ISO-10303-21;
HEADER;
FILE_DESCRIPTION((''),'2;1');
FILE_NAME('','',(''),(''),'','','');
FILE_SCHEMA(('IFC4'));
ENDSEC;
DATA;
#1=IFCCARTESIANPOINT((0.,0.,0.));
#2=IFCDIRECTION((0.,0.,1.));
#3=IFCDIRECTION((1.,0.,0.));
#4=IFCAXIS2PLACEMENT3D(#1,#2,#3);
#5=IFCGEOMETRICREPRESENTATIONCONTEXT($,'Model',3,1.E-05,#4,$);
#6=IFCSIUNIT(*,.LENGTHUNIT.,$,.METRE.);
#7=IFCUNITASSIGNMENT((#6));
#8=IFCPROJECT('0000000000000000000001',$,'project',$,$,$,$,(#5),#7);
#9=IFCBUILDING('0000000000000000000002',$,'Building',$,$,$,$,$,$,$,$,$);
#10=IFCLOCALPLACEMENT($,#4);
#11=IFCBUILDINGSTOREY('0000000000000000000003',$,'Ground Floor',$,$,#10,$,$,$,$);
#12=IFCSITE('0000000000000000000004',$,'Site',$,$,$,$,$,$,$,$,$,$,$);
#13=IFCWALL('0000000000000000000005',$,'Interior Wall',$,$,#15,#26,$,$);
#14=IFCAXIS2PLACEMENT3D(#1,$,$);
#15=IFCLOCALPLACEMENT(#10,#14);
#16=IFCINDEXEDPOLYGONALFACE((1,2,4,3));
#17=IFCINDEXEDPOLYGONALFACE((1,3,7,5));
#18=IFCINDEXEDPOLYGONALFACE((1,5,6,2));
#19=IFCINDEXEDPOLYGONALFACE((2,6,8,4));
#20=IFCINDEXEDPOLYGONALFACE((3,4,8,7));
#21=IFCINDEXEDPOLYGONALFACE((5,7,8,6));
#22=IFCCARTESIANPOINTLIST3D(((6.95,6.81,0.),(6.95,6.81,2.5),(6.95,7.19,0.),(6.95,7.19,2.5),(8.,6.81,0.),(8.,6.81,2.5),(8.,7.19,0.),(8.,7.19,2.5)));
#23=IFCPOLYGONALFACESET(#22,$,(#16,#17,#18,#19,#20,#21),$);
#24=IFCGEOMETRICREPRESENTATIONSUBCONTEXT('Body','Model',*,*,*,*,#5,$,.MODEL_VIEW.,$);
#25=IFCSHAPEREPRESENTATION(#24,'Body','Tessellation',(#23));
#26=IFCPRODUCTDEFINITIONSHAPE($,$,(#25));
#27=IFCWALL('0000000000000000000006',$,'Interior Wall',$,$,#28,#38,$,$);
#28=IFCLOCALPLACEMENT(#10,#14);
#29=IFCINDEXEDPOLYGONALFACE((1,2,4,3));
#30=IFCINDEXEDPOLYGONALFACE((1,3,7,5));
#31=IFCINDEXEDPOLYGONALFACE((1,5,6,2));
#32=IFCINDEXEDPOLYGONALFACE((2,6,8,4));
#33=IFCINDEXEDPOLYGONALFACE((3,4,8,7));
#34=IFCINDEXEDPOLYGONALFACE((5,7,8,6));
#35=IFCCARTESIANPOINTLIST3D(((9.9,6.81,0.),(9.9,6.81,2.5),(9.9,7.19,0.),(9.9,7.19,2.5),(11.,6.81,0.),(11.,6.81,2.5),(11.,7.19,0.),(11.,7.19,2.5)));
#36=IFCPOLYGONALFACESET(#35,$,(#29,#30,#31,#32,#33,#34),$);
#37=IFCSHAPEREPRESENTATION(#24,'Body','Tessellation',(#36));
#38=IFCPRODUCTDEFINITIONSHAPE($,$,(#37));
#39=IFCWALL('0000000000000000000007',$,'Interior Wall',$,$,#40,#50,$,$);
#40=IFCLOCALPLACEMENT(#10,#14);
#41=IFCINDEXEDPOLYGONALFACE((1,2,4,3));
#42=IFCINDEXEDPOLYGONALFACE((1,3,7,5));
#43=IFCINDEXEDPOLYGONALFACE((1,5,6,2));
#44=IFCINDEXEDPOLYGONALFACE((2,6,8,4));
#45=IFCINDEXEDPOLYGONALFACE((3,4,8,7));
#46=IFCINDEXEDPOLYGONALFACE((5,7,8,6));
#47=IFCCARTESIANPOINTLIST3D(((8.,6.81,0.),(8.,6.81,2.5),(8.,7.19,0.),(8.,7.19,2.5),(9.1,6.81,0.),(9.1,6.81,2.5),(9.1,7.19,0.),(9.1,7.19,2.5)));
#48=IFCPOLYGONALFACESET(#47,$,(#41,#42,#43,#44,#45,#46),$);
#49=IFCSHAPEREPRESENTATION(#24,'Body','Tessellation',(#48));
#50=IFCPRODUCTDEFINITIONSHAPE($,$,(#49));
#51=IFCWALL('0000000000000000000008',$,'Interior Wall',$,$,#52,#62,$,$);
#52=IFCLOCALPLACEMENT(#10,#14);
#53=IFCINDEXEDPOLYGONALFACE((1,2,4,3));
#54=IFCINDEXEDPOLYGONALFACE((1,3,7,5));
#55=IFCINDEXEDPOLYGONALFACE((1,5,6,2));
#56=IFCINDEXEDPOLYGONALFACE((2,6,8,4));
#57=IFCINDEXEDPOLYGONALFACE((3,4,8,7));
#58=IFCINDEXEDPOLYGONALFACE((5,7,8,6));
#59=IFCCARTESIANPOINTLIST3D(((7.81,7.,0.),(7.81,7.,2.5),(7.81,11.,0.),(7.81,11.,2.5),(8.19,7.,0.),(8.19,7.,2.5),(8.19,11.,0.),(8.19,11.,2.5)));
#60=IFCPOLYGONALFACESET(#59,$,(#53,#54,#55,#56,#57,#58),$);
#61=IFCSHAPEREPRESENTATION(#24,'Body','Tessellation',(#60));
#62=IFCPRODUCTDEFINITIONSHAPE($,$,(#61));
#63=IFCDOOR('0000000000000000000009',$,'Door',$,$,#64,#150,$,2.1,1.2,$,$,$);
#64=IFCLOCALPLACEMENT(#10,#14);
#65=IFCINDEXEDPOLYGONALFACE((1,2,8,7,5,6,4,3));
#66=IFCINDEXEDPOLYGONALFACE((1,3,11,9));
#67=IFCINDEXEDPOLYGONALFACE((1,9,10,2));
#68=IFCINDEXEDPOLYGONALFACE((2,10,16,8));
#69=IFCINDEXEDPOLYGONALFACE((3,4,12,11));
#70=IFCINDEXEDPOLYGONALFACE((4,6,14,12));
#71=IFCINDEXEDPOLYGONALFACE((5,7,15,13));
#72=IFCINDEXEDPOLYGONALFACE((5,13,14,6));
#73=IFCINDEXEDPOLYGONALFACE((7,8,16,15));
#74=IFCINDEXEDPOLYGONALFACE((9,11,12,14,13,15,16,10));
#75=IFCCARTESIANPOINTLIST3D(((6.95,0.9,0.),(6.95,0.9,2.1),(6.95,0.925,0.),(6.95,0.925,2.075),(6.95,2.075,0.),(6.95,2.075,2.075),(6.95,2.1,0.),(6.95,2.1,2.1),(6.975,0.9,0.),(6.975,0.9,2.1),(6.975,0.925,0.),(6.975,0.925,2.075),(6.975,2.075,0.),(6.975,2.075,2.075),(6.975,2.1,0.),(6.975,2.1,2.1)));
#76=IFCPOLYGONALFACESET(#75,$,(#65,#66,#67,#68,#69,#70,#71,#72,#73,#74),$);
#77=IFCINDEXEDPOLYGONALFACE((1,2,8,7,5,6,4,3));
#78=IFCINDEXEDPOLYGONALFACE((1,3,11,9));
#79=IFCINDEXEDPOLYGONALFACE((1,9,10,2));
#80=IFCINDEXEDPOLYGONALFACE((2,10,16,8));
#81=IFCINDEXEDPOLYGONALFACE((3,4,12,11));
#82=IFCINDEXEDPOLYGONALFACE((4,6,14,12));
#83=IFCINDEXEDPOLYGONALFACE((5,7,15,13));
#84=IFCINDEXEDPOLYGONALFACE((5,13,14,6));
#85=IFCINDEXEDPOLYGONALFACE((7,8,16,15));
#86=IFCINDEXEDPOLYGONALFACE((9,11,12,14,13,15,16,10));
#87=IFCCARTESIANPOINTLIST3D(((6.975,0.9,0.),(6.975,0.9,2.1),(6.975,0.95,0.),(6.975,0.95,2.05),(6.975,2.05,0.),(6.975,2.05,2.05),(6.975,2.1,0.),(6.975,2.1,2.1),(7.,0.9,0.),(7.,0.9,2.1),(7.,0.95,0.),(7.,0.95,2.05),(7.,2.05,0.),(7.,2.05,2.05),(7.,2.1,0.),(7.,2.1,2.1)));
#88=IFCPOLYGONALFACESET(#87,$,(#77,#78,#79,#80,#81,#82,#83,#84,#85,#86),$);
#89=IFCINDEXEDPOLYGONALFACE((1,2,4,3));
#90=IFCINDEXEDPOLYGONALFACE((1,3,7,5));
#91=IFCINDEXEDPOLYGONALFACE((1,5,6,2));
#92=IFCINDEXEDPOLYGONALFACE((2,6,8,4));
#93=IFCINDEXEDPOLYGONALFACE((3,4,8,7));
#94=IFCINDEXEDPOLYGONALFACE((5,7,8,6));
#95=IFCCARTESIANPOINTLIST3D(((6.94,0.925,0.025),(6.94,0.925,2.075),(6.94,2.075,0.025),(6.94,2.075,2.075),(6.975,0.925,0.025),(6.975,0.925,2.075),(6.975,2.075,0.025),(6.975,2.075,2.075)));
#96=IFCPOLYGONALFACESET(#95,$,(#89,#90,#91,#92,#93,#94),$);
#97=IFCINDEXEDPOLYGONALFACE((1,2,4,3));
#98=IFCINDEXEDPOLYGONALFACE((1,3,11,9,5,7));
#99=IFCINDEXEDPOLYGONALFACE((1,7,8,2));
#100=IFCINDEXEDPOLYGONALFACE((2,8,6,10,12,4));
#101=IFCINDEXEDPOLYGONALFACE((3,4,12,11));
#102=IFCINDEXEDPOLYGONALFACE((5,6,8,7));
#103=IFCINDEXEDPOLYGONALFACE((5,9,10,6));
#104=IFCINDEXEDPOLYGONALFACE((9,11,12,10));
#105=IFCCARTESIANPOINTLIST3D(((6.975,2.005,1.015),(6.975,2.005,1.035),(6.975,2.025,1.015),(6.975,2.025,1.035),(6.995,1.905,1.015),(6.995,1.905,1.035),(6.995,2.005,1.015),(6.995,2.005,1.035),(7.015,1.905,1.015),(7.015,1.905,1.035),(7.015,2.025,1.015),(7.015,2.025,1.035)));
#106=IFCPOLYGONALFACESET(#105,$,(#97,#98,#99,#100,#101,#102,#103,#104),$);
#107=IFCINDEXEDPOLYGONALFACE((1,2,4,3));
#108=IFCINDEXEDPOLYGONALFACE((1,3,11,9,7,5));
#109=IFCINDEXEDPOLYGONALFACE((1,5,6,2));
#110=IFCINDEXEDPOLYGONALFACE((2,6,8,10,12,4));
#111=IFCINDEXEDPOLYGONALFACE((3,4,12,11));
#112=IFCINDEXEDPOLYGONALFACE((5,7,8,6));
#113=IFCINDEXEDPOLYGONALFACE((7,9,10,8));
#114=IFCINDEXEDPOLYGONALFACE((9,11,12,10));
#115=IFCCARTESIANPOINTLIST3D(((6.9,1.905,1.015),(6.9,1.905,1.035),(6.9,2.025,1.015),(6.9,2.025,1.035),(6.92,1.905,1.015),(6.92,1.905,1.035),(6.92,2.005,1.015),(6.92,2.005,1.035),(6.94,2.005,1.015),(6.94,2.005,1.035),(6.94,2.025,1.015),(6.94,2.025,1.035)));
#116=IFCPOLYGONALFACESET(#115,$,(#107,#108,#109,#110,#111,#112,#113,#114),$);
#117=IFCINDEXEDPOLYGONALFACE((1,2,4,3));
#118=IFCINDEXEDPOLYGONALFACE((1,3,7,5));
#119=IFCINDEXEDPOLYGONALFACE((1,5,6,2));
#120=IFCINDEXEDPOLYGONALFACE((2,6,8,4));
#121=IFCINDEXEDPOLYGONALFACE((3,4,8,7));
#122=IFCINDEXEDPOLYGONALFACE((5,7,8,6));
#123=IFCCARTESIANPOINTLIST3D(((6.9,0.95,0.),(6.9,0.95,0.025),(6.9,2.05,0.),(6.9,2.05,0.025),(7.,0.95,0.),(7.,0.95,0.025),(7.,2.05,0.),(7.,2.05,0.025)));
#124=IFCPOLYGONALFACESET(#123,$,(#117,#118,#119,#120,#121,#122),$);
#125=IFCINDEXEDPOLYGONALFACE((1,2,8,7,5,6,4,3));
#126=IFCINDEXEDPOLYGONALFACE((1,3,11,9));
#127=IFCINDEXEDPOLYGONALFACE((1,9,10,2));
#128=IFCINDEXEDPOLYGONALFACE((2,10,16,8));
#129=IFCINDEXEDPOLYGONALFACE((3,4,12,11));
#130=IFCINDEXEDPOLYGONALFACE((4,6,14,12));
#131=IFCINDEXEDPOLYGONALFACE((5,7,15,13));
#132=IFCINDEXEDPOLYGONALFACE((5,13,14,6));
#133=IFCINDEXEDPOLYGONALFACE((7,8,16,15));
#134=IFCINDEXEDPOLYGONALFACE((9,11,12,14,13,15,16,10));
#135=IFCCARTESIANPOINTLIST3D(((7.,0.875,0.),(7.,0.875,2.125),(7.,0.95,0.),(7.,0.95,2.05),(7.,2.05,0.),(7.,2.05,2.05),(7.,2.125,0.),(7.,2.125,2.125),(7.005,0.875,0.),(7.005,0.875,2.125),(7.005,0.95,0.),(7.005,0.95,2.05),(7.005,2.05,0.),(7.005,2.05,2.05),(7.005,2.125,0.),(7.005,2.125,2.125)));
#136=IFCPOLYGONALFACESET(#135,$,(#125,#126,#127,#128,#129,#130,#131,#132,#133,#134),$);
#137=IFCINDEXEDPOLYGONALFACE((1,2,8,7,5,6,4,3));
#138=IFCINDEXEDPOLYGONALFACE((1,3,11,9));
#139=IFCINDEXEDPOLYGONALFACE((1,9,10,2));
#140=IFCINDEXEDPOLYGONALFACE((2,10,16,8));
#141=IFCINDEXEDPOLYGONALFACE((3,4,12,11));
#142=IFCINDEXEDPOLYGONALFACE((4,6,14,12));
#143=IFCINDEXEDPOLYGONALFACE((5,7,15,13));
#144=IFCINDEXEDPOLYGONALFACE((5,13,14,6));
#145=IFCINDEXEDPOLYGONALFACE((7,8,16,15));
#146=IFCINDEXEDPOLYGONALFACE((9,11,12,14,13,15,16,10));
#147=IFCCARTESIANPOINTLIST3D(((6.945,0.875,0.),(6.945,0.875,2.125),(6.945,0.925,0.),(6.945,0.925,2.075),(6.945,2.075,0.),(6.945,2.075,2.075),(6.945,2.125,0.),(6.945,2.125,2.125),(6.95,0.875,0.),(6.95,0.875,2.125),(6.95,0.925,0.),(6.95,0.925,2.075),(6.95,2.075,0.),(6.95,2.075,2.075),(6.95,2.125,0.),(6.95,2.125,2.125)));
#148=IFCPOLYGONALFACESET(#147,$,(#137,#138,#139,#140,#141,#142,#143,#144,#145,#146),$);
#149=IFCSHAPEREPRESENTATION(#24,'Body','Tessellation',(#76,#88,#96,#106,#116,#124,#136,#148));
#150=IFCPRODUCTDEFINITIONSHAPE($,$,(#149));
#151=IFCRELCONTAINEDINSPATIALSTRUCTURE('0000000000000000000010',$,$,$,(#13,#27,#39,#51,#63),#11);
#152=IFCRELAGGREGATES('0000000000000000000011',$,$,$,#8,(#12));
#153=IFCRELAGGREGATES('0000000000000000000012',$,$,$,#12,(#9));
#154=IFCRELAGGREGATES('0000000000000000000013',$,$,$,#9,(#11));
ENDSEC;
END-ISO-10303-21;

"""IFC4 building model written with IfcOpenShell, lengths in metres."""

from ifc_helpers import new_model, si_unit, frame, origin_with_axes, place, context, subcontext, project, spatial, line, indexed_curve, outline, extrude, element, save


model = new_model("IFC4")

# Units and contexts
model_context = context("Model", 3, precision=1e-05, world=origin_with_axes())
body_context = subcontext(model_context, "Body", "Model", "MODEL_VIEW")
ifc_project = project(units=[si_unit("LENGTHUNIT", "METRE")], contexts=[model_context])

# Site, building, storey
site = spatial("IfcSite", under=ifc_project, Name="Site")
building = spatial("IfcBuilding", under=site, Name="Building")
storey_placement = place(None, origin_with_axes())
storey = spatial("IfcBuildingStorey", under=building, at=storey_placement, Name="Ground Floor")

# Walls
wall_1_placement = place(storey_placement, frame((8.0, 7.0, 0.0), z_axis=(0.0, 0.0, 1.0), x_axis=(-1.0, 0.0, 0.0)))
element("IfcWall", 1, at=wall_1_placement, inside=storey, Name="Interior Wall", context=body_context, shape_type="SweptSolid", body=[
    extrude(outline(indexed_curve([(0.0, 0.0), (0.0, 0.38), (1.05, 0.38), (1.05, 0.0), (0.0, 0.0)], self_intersect=False)), frame((0.0, -0.19, 0.0), z_axis=(0.0, 0.0, 1.0), x_axis=(1.0, 0.0, 0.0)), (0.0, 0.0, 1.0), 2.5),
])
for number, where, z_axis, x_axis, name in (
    (2, (11.0, 7.0, 0.0), (0.0, 0.0, 1.0), (-1.0, 0.0, 0.0), "Interior Wall"),
    (3, (9.1, 7.0, 0.0), (0.0, 0.0, 1.0), (-1.0, 0.0, 0.0), "Interior Wall"),
):
    element("IfcWall", number, at=place(storey_placement, frame(where, z_axis=z_axis, x_axis=x_axis)), inside=storey, Name=name, context=body_context, shape_type="SweptSolid", body=[
        extrude(outline(indexed_curve([(0.0, 0.0), (0.0, 0.38), (1.1, 0.38), (1.1, 0.0), (0.0, 0.0)], self_intersect=False)), frame((0.0, -0.19, 0.0), z_axis=(0.0, 0.0, 1.0), x_axis=(1.0, 0.0, 0.0)), (0.0, 0.0, 1.0), 2.5),
    ])
wall_2_placement = place(storey_placement, frame((8.0, 7.0, 0.0), z_axis=(0.0, 0.0, 1.0), x_axis=(0.0, 1.0, 0.0)))
element("IfcWall", 4, at=wall_2_placement, inside=storey, Name="Interior Wall", context=body_context, shape_type="SweptSolid", body=[
    extrude(outline(indexed_curve([(0.0, 0.0), (0.0, 0.38), (4.0, 0.38), (4.0, 0.0), (0.0, 0.0)], self_intersect=False)), frame((0.0, -0.19, 0.0), z_axis=(0.0, 0.0, 1.0), x_axis=(1.0, 0.0, 0.0)), (0.0, 0.0, 1.0), 2.5),
])

# Door
door_1_placement = place(storey_placement, frame((7.0, 0.9, 0.0), z_axis=(0.0, 0.0, 1.0), x_axis=(0.0, 1.0, 0.0)))
element("IfcDoor", 5, at=door_1_placement, inside=storey, Name="Door", OverallHeight=2.1, OverallWidth=1.2, context=body_context, shape_type="SweptSolid", body=[
    extrude(outline(indexed_curve([(0.0, 0.0), (0.0, 2.1), (1.2, 2.1), (1.2, 0.0), (1.175, 0.0), (1.175, 2.075), (0.025, 2.075), (0.025, 0.0)], segments=[line(1, 2, 3, 4, 5, 6, 7, 8, 1)])), frame((0.0, 0.025, 0.0), z_axis=(0.0, -1.0, 0.0), x_axis=(1.0, 0.0, 0.0)), (0.0, 0.0, -1.0), 0.025),
    extrude(outline(indexed_curve([(0.0, 0.0), (0.0, 2.1), (1.2, 2.1), (1.2, 0.0), (1.15, 0.0), (1.15, 2.05), (0.05, 2.05), (0.05, 0.0)], segments=[line(1, 2, 3, 4, 5, 6, 7, 8, 1)])), frame((0.0, 0.0, 0.0), z_axis=(0.0, -1.0, 0.0), x_axis=(1.0, 0.0, 0.0)), (0.0, 0.0, -1.0), 0.025),
    extrude(outline(indexed_curve([(0.0, 0.0), (1.15, 0.0), (1.15, 0.035), (0.0, 0.035)], segments=[line(1, 2, 3, 4, 1)])), frame((0.025, 0.025, 0.025), z_axis=(0.0, 0.0, 1.0), x_axis=(1.0, 0.0, 0.0)), (0.0, 0.0, 1.0), 2.05),
    extrude(outline(indexed_curve([(0.0, 0.0), (0.0, -0.04), (-0.12, -0.04), (-0.12, -0.02), (-0.02, -0.02), (-0.02, 0.0)], segments=[line(1, 2, 3, 4, 5, 6, 1)])), frame((1.125, 0.025, 1.015), z_axis=(0.0, 0.0, 1.0), x_axis=(1.0, 0.0, 0.0)), (0.0, 0.0, 1.0), 0.02),
    extrude(outline(indexed_curve([(0.0, 0.0), (0.0, 0.04), (-0.12, 0.04), (-0.12, 0.02), (-0.02, 0.02), (-0.02, 0.0)], segments=[line(1, 2, 3, 4, 5, 6, 1)])), frame((1.125, 0.06, 1.015), z_axis=(0.0, 0.0, 1.0), x_axis=(1.0, 0.0, 0.0)), (0.0, 0.0, 1.0), 0.02),
    extrude(outline(indexed_curve([(0.0, 0.0), (1.1, 0.0), (1.1, 0.1), (0.0, 0.1)], segments=[line(1, 2, 3, 4, 1)])), frame((0.05, 0.0, 0.0), z_axis=(0.0, 0.0, 1.0), x_axis=(1.0, 0.0, 0.0)), (0.0, 0.0, 1.0), 0.025),
    extrude(outline(indexed_curve([(0.0, 0.0), (0.0, 2.125), (1.25, 2.125), (1.25, 0.0), (1.175, 0.0), (1.175, 2.05), (0.075, 2.05), (0.075, 0.0)], segments=[line(1, 2, 3, 4, 5, 6, 7, 8, 1)])), frame((-0.025, -0.005, 0.0), z_axis=(0.0, -1.0, 0.0), x_axis=(1.0, 0.0, 0.0)), (0.0, 0.0, -1.0), 0.005),
    extrude(outline(indexed_curve([(0.0, 0.0), (0.0, 2.125), (1.25, 2.125), (1.25, 0.0), (1.2, 0.0), (1.2, 2.075), (0.05, 2.075), (0.05, 0.0)], segments=[line(1, 2, 3, 4, 5, 6, 7, 8, 1)])), frame((-0.025, 0.05, 0.0), z_axis=(0.0, -1.0, 0.0), x_axis=(1.0, 0.0, 0.0)), (0.0, 0.0, -1.0), 0.005),
])

save(model, "model.ifc")
